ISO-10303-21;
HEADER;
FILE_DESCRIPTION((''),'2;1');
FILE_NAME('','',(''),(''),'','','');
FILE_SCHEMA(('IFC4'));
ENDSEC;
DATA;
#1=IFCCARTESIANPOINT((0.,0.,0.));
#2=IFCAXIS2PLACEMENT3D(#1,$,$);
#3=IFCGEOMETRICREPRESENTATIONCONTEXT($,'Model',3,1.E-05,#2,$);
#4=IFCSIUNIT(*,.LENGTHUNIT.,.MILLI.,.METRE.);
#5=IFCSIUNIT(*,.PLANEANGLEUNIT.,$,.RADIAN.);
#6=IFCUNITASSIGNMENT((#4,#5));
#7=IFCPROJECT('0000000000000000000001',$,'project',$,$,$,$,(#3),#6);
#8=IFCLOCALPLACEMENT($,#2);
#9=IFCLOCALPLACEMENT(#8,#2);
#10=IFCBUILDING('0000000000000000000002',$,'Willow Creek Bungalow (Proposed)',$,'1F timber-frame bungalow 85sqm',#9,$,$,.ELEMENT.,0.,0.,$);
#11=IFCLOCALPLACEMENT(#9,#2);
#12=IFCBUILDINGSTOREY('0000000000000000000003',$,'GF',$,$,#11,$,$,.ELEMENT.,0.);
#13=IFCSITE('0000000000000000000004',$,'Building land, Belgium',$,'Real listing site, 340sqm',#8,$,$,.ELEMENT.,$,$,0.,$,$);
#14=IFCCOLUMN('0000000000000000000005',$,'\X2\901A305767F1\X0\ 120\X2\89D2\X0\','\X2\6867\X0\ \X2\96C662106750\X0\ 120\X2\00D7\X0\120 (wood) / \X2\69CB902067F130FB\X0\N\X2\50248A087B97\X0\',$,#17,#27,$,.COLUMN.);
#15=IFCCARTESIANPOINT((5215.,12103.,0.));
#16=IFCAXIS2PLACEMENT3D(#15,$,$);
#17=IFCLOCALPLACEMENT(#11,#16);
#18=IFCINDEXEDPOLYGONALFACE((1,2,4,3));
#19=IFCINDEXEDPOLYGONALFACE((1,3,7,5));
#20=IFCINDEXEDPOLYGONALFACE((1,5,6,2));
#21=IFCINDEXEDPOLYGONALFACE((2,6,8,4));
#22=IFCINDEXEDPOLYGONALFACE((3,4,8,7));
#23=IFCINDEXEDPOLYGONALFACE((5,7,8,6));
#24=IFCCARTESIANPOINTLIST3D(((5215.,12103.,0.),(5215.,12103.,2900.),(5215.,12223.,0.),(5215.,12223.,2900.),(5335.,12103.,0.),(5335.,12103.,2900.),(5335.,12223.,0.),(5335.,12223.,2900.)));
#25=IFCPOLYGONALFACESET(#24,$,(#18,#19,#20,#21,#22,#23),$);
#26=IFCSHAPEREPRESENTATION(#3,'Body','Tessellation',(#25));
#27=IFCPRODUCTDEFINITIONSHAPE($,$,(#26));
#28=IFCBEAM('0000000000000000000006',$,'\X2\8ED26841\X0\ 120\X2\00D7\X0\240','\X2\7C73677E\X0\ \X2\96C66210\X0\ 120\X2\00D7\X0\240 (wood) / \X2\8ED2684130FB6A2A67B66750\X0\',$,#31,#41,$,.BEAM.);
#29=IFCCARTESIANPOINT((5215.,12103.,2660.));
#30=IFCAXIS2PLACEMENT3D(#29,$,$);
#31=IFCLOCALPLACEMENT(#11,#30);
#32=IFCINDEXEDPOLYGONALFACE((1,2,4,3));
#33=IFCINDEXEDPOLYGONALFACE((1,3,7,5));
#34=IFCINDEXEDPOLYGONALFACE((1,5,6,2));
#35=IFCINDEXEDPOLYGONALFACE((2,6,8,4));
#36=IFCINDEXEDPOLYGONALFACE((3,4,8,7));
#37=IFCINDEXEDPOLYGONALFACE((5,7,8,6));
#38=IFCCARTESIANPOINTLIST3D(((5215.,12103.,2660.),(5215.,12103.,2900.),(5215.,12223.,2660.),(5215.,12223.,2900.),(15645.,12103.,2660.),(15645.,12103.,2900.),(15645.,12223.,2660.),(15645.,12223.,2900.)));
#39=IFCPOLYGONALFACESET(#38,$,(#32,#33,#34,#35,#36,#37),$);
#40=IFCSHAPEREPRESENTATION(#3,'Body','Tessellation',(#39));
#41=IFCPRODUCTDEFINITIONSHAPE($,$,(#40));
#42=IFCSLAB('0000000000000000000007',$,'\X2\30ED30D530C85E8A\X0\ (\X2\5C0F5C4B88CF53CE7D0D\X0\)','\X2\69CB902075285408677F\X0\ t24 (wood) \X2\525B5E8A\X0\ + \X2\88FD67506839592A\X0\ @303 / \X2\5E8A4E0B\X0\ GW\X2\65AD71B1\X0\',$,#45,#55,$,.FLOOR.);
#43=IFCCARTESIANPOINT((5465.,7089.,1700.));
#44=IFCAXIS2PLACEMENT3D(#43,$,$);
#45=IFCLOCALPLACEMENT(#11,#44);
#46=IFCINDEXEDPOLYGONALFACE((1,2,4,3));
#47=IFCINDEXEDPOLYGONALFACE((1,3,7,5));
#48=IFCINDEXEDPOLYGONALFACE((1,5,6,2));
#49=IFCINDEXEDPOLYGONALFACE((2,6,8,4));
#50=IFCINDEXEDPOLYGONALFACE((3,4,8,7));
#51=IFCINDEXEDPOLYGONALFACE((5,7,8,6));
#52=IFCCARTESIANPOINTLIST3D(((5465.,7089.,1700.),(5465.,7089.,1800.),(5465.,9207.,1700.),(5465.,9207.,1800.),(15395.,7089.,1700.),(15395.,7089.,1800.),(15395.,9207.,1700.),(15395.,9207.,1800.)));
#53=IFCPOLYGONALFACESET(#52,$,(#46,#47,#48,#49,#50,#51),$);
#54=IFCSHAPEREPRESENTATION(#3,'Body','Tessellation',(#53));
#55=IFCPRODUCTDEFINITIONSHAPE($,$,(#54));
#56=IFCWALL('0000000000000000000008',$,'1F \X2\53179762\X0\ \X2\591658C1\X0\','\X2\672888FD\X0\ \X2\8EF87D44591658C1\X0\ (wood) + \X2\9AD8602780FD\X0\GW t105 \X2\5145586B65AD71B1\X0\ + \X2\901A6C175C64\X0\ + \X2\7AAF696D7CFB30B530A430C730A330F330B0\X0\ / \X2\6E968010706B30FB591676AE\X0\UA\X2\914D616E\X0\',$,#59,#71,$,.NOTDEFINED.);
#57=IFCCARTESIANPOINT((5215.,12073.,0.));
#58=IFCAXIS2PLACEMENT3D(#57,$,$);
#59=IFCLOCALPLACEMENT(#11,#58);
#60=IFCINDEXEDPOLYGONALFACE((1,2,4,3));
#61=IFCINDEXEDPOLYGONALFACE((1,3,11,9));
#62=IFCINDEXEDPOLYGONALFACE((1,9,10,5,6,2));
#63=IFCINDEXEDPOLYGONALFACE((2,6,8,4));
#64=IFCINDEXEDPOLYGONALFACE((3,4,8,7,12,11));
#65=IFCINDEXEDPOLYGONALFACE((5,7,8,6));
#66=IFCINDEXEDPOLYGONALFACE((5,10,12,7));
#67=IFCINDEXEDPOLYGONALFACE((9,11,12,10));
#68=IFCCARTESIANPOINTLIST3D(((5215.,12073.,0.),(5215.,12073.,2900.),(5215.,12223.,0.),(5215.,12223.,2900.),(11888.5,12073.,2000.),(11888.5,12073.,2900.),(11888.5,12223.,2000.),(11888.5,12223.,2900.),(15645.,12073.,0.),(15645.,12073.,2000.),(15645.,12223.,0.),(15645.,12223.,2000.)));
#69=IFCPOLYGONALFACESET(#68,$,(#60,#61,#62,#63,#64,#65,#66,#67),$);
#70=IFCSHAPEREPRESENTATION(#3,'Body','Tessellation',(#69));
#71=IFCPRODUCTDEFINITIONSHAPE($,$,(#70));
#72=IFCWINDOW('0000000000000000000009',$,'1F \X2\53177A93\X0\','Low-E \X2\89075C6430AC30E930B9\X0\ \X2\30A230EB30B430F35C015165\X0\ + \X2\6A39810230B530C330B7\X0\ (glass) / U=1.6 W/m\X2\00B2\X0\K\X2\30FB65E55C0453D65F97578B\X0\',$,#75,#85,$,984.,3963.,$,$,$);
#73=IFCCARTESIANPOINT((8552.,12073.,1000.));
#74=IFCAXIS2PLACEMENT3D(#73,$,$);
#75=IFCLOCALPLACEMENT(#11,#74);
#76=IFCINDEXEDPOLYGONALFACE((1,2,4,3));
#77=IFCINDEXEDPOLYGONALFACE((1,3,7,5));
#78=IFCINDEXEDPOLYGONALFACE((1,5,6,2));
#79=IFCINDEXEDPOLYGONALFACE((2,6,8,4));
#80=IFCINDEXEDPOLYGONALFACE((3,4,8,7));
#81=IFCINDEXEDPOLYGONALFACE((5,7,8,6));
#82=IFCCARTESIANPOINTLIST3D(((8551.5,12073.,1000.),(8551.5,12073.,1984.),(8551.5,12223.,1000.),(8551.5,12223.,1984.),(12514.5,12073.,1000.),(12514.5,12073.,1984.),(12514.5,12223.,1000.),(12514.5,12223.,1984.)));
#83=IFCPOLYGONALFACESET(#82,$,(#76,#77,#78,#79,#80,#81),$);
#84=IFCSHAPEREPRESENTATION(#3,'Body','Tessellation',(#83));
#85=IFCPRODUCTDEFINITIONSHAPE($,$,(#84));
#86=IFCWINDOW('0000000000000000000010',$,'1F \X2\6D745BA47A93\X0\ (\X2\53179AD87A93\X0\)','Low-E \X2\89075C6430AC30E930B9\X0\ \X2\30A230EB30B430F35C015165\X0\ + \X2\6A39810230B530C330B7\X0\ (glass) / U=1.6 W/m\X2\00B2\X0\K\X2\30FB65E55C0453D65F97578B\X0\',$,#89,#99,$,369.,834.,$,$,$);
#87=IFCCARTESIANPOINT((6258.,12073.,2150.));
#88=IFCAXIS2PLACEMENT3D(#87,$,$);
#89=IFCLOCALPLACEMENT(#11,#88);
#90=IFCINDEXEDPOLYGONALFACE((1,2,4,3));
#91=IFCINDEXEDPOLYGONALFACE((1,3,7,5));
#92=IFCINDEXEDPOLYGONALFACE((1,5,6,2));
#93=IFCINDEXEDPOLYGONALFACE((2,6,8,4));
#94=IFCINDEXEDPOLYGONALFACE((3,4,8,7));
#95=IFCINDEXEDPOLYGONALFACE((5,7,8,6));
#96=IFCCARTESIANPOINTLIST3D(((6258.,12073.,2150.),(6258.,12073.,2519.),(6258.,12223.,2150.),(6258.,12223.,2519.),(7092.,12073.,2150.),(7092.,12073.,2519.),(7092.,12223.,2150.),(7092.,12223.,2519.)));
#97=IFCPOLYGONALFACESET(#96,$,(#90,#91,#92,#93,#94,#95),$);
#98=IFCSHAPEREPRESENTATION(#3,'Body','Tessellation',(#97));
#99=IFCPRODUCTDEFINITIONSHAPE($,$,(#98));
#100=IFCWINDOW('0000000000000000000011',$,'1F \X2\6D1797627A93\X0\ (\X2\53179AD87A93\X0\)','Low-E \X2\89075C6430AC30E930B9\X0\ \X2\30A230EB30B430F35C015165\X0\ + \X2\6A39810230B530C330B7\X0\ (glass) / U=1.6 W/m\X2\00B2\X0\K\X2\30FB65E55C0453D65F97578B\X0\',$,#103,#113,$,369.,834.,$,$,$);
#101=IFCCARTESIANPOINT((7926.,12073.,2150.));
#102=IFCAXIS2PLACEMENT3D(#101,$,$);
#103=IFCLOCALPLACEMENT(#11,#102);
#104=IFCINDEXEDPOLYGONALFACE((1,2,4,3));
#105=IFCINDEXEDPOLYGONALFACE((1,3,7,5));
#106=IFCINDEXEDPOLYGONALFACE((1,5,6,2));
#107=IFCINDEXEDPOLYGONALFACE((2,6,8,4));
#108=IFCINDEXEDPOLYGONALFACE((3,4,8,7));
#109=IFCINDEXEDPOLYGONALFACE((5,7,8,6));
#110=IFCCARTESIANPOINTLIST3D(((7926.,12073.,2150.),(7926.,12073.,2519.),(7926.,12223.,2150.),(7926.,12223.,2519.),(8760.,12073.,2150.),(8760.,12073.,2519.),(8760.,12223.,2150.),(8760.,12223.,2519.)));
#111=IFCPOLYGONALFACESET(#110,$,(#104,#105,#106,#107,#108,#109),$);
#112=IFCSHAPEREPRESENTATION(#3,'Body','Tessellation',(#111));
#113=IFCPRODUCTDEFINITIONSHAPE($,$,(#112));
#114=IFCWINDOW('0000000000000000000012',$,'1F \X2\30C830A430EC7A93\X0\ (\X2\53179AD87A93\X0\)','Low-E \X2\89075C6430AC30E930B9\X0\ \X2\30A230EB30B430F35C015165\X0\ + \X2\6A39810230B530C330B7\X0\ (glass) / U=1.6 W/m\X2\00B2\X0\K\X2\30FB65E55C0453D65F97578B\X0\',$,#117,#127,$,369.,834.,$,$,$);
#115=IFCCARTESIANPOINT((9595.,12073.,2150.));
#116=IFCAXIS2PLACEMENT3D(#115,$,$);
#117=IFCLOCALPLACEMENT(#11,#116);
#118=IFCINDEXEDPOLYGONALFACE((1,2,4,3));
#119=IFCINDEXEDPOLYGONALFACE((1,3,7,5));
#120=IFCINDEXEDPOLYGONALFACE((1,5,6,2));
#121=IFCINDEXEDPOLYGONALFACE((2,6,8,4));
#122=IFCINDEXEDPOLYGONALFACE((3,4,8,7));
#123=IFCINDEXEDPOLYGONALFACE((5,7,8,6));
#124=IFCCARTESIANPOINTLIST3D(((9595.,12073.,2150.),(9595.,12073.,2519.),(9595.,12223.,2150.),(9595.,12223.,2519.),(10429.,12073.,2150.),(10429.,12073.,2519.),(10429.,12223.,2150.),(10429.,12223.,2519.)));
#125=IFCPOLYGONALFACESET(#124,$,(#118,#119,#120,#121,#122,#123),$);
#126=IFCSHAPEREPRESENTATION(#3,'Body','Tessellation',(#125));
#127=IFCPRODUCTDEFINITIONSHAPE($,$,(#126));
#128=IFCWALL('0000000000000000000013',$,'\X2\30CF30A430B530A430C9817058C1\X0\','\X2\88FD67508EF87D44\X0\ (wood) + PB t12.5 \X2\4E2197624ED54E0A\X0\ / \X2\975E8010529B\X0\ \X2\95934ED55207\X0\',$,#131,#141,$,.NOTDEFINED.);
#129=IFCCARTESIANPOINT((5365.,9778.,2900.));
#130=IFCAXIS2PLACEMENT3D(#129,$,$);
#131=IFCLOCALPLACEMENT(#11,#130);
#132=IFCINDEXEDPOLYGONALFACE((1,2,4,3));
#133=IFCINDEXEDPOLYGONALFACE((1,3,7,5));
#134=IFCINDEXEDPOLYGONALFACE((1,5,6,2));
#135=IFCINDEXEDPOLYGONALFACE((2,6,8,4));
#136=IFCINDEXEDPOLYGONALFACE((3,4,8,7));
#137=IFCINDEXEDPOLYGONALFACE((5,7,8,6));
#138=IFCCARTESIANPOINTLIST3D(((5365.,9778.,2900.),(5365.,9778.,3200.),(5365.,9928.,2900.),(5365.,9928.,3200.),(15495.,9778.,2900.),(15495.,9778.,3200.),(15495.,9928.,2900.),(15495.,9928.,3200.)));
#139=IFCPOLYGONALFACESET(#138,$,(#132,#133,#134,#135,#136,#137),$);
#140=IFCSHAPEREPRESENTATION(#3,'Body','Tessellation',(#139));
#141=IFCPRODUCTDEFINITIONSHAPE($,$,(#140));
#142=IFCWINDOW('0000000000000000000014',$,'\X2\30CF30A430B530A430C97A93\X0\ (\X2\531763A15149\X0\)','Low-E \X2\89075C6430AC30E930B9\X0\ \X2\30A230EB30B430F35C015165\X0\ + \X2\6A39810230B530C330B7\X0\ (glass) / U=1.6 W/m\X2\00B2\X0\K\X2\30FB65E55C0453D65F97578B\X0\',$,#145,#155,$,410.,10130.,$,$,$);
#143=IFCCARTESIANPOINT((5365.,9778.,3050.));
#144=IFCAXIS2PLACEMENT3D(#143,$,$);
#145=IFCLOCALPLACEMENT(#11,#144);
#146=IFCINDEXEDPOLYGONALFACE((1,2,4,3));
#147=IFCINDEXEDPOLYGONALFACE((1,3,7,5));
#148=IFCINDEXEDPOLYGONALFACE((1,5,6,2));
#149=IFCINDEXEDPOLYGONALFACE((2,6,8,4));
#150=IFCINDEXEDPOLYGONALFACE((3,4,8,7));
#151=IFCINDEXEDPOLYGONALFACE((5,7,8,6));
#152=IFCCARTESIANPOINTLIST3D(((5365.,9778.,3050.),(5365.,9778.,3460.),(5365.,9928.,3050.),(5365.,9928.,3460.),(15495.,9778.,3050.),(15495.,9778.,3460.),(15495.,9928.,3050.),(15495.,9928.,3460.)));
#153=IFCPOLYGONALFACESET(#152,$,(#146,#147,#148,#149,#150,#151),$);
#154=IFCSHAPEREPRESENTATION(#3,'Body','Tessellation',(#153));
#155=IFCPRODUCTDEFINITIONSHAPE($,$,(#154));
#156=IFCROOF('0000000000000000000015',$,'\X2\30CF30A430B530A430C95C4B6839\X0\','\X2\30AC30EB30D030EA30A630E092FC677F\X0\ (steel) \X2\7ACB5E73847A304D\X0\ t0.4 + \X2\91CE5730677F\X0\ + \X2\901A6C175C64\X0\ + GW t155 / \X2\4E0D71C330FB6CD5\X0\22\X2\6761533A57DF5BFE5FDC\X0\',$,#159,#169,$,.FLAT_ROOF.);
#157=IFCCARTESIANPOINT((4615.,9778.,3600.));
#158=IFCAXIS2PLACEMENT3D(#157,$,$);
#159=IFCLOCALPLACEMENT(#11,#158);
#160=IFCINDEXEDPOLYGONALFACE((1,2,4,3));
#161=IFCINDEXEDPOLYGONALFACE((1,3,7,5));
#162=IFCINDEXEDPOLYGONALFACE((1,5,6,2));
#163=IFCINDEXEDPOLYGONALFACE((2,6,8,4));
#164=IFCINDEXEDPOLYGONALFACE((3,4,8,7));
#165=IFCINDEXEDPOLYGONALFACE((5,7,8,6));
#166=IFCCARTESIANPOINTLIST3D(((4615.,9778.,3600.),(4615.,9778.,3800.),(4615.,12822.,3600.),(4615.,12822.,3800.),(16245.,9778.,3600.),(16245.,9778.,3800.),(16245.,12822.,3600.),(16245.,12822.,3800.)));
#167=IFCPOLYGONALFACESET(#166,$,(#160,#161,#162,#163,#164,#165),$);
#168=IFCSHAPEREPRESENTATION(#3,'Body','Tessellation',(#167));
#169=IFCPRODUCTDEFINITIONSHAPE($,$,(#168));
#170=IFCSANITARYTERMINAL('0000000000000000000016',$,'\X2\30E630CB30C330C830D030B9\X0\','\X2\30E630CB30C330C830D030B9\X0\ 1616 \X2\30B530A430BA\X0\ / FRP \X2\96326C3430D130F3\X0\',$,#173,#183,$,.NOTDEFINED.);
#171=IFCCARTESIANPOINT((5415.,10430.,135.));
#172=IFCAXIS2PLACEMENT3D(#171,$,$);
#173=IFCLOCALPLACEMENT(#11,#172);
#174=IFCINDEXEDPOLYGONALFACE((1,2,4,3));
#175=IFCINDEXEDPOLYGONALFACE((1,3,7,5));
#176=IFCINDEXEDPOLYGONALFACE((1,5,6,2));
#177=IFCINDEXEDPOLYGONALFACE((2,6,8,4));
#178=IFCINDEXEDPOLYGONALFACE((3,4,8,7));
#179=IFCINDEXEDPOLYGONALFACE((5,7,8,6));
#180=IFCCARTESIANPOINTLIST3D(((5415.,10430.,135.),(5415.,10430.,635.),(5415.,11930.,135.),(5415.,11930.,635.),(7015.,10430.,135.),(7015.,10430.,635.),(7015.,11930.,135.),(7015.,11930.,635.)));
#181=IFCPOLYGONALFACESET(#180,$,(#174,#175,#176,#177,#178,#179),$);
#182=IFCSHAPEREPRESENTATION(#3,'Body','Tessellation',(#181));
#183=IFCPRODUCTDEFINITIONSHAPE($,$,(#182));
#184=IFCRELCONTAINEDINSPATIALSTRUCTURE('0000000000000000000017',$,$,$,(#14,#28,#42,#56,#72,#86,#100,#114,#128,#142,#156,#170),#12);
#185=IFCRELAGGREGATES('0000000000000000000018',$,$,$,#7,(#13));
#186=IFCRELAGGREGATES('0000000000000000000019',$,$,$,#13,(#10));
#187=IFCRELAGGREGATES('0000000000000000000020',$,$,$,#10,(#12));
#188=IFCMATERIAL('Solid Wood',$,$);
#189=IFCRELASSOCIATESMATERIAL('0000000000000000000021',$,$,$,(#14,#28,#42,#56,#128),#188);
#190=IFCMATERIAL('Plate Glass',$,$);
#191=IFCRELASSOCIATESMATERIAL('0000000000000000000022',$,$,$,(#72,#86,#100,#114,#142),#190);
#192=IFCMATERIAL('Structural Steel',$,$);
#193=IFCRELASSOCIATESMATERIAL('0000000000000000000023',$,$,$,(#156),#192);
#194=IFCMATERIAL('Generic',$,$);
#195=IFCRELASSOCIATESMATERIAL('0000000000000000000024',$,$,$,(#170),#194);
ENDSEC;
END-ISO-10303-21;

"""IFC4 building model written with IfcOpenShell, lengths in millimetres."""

from ifc_helpers import new_model, si_unit, frame, frame_2d, origin, place, context, project, spatial, rectangle, extrude, material, element, fill, save


model = new_model("IFC4")

# Units and contexts
model_context = context("Model", 3, precision=1e-05, world=origin())
ifc_project = project(units=[si_unit("LENGTHUNIT", "METRE", prefix="MILLI"), si_unit("PLANEANGLEUNIT", "RADIAN")], contexts=[model_context])

# Site, building, storey
site_placement = place(None, origin())
site = spatial("IfcSite", under=ifc_project, at=site_placement, Name="Building land, Belgium", ObjectType="Real listing site, 340sqm", CompositionType="ELEMENT", RefElevation=0.0)
building_placement = place(site_placement, origin())
building = spatial("IfcBuilding", under=site, at=building_placement, Name="Willow Creek Bungalow (Proposed)", ObjectType="1F timber-frame bungalow 85sqm", CompositionType="ELEMENT", ElevationOfRefHeight=0.0, ElevationOfTerrain=0.0)
storey_placement = place(building_placement, origin())
storey = spatial("IfcBuildingStorey", under=building, at=storey_placement, Name="GF", CompositionType="ELEMENT", Elevation=0.0)

# Column
ifc_material_1 = material(Name="Solid Wood")
column_1_placement = place(storey_placement, frame((5215.0, 12103.0, 0.0)))
element("IfcColumn", 1, at=column_1_placement, inside=storey, material=ifc_material_1, Name="通し柱 120角", Description="桧 集成材 120×120 (wood) / 構造柱・N値計算", PredefinedType="COLUMN", context=model_context, shape_type="SweptSolid", body=[
    extrude(rectangle(XDim=120.0, YDim=120.0, at=frame_2d((60.0, 60.0))), frame((5215.0, 12103.0, 0.0)), (0.0, 0.0, 1.0), 2900.0),
])

# Beam
beam_1_placement = place(storey_placement, frame((5215.0, 12103.0, 2660.0)))
element("IfcBeam", 2, at=beam_1_placement, inside=storey, material=ifc_material_1, Name="軒桁 120×240", Description="米松 集成 120×240 (wood) / 軒桁・横架材", PredefinedType="BEAM", context=model_context, shape_type="SweptSolid", body=[
    extrude(rectangle(XDim=10430.0, YDim=120.0, at=frame_2d((5215.0, 60.0))), frame((5215.0, 12103.0, 2660.0)), (0.0, 0.0, 1.0), 240.0),
])

# Slab
slab_placement = place(storey_placement, frame((5465.0, 7089.0, 1700.0)))
element("IfcSlab", 3, at=slab_placement, inside=storey, material=ifc_material_1, Name="ロフト床 (小屋裏収納)", Description="構造用合板 t24 (wood) 剛床 + 製材根太 @303 / 床下 GW断熱", PredefinedType="FLOOR", context=model_context, shape_type="SweptSolid", body=[
    extrude(rectangle(XDim=9930.0, YDim=2118.0, at=frame_2d((4965.0, 1059.0))), frame((5465.0, 7089.0, 1700.0)), (0.0, 0.0, 1.0), 100.0),
])

# Wall, openings, windows
wall_1_placement = place(storey_placement, frame((5215.0, 12073.0, 0.0)))
wall_1 = element("IfcWall", 4, at=wall_1_placement, inside=storey, material=ifc_material_1, Name="1F 北面 外壁", Description="木製 軸組外壁 (wood) + 高性能GW t105 充填断熱 + 通気層 + 窯業系サイディング / 準耐火・外皮UA配慮", PredefinedType="NOTDEFINED", context=model_context, shape_type="SweptSolid", body=[
    extrude(rectangle(XDim=10430.0, YDim=150.0, at=frame_2d((5215.0, 75.0))), frame((5215.0, 12073.0, 0.0)), (0.0, 0.0, 1.0), 2900.0),
])
opening_1_placement = place(storey_placement, frame((8552.0, 12073.0, 1000.0)))
opening_1 = element("IfcOpeningElement", 5, at=opening_1_placement, cuts=wall_1, PredefinedType="NOTDEFINED", context=model_context, shape_type="SweptSolid", body=[
    extrude(rectangle(XDim=3963.0, YDim=150.0, at=frame_2d((1981.0, 75.0))), frame((8552.0, 12073.0, 1000.0)), (0.0, 0.0, 1.0), 984.0),
])
opening_2_placement = place(storey_placement, frame((6258.0, 12073.0, 2150.0)))
opening_2 = element("IfcOpeningElement", 6, at=opening_2_placement, cuts=wall_1, PredefinedType="NOTDEFINED", context=model_context, shape_type="SweptSolid", body=[
    extrude(rectangle(XDim=834.0, YDim=150.0, at=frame_2d((417.0, 75.0))), frame((6258.0, 12073.0, 2150.0)), (0.0, 0.0, 1.0), 369.0),
])
opening_3_placement = place(storey_placement, frame((7926.0, 12073.0, 2150.0)))
opening_3 = element("IfcOpeningElement", 7, at=opening_3_placement, cuts=wall_1, PredefinedType="NOTDEFINED", context=model_context, shape_type="SweptSolid", body=[
    extrude(rectangle(XDim=834.0, YDim=150.0, at=frame_2d((417.0, 75.0))), frame((7926.0, 12073.0, 2150.0)), (0.0, 0.0, 1.0), 369.0),
])
opening_4_placement = place(storey_placement, frame((9595.0, 12073.0, 2150.0)))
opening_4 = element("IfcOpeningElement", 8, at=opening_4_placement, cuts=wall_1, PredefinedType="NOTDEFINED", context=model_context, shape_type="SweptSolid", body=[
    extrude(rectangle(XDim=834.0, YDim=150.0, at=frame_2d((417.0, 75.0))), frame((9595.0, 12073.0, 2150.0)), (0.0, 0.0, 1.0), 369.0),
])
ifc_material_2 = material(Name="Plate Glass")
window_1_placement = place(storey_placement, frame((8552.0, 12073.0, 1000.0)))
window_1 = element("IfcWindow", 9, at=window_1_placement, inside=storey, material=ifc_material_2, Name="1F 北窓", Description="Low-E 複層ガラス アルゴン封入 + 樹脂サッシ (glass) / U=1.6 W/m²K・日射取得型", OverallHeight=984.0, OverallWidth=3963.0, context=model_context, shape_type="SweptSolid", body=[
    extrude(rectangle(XDim=3963.0, YDim=150.0, at=frame_2d((1981.0, 75.0))), frame((8552.0, 12073.0, 1000.0)), (0.0, 0.0, 1.0), 984.0),
])
fill(opening_1, window_1)
window_2_placement = place(storey_placement, frame((6258.0, 12073.0, 2150.0)))
window_2 = element("IfcWindow", 10, at=window_2_placement, inside=storey, material=ifc_material_2, Name="1F 浴室窓 (北高窓)", Description="Low-E 複層ガラス アルゴン封入 + 樹脂サッシ (glass) / U=1.6 W/m²K・日射取得型", OverallHeight=369.0, OverallWidth=834.0, context=model_context, shape_type="SweptSolid", body=[
    extrude(rectangle(XDim=834.0, YDim=150.0, at=frame_2d((417.0, 75.0))), frame((6258.0, 12073.0, 2150.0)), (0.0, 0.0, 1.0), 369.0),
])
fill(opening_2, window_2)
window_3_placement = place(storey_placement, frame((7926.0, 12073.0, 2150.0)))
window_3 = element("IfcWindow", 11, at=window_3_placement, inside=storey, material=ifc_material_2, Name="1F 洗面窓 (北高窓)", Description="Low-E 複層ガラス アルゴン封入 + 樹脂サッシ (glass) / U=1.6 W/m²K・日射取得型", OverallHeight=369.0, OverallWidth=834.0, context=model_context, shape_type="SweptSolid", body=[
    extrude(rectangle(XDim=834.0, YDim=150.0, at=frame_2d((417.0, 75.0))), frame((7926.0, 12073.0, 2150.0)), (0.0, 0.0, 1.0), 369.0),
])
fill(opening_3, window_3)
window_4_placement = place(storey_placement, frame((9595.0, 12073.0, 2150.0)))
window_4 = element("IfcWindow", 12, at=window_4_placement, inside=storey, material=ifc_material_2, Name="1F トイレ窓 (北高窓)", Description="Low-E 複層ガラス アルゴン封入 + 樹脂サッシ (glass) / U=1.6 W/m²K・日射取得型", OverallHeight=369.0, OverallWidth=834.0, context=model_context, shape_type="SweptSolid", body=[
    extrude(rectangle(XDim=834.0, YDim=150.0, at=frame_2d((417.0, 75.0))), frame((9595.0, 12073.0, 2150.0)), (0.0, 0.0, 1.0), 369.0),
])
fill(opening_4, window_4)

# Wall, opening, window
wall_2_placement = place(storey_placement, frame((5365.0, 9778.0, 2900.0)))
wall_2 = element("IfcWall", 13, at=wall_2_placement, inside=storey, material=ifc_material_1, Name="ハイサイド腰壁", Description="製材軸組 (wood) + PB t12.5 両面仕上 / 非耐力 間仕切", PredefinedType="NOTDEFINED", context=model_context, shape_type="SweptSolid", body=[
    extrude(rectangle(XDim=10130.0, YDim=150.0, at=frame_2d((5065.0, 75.0))), frame((5365.0, 9778.0, 2900.0)), (0.0, 0.0, 1.0), 700.0),
])
opening_5_placement = place(storey_placement, frame((5365.0, 9778.0, 3050.0)))
opening_5 = element("IfcOpeningElement", 14, at=opening_5_placement, cuts=wall_2, PredefinedType="NOTDEFINED", context=model_context, shape_type="SweptSolid", body=[
    extrude(rectangle(XDim=10130.0, YDim=150.0, at=frame_2d((5065.0, 75.0))), frame((5365.0, 9778.0, 3050.0)), (0.0, 0.0, 1.0), 410.0),
])
window_5_placement = place(storey_placement, frame((5365.0, 9778.0, 3050.0)))
window_5 = element("IfcWindow", 15, at=window_5_placement, inside=storey, material=ifc_material_2, Name="ハイサイド窓 (北採光)", Description="Low-E 複層ガラス アルゴン封入 + 樹脂サッシ (glass) / U=1.6 W/m²K・日射取得型", OverallHeight=410.0, OverallWidth=10130.0, context=model_context, shape_type="SweptSolid", body=[
    extrude(rectangle(XDim=10130.0, YDim=150.0, at=frame_2d((5065.0, 75.0))), frame((5365.0, 9778.0, 3050.0)), (0.0, 0.0, 1.0), 410.0),
])
fill(opening_5, window_5)

# Roof
ifc_material_3 = material(Name="Structural Steel")
roof_placement = place(storey_placement, frame((4615.0, 9778.0, 3600.0)))
element("IfcRoof", 16, at=roof_placement, inside=storey, material=ifc_material_3, Name="ハイサイド屋根", Description="ガルバリウム鋼板 (steel) 立平葺き t0.4 + 野地板 + 通気層 + GW t155 / 不燃・法22条区域対応", PredefinedType="FLAT_ROOF", context=model_context, shape_type="SweptSolid", body=[
    extrude(rectangle(XDim=11630.0, YDim=3044.0, at=frame_2d((5815.0, 1522.0))), frame((4615.0, 9778.0, 3600.0)), (0.0, 0.0, 1.0), 200.0),
])

# Sanitary terminal
ifc_material_4 = material(Name="Generic")
sanitary_terminal_placement = place(storey_placement, frame((5415.0, 10430.0, 135.0)))
element("IfcSanitaryTerminal", 17, at=sanitary_terminal_placement, inside=storey, material=ifc_material_4, Name="ユニットバス", Description="ユニットバス 1616 サイズ / FRP 防水パン", PredefinedType="NOTDEFINED", context=model_context, shape_type="SweptSolid", body=[
    extrude(rectangle(XDim=1600.0, YDim=1500.0, at=frame_2d((800.0, 750.0))), frame((5415.0, 10430.0, 135.0)), (0.0, 0.0, 1.0), 500.0),
])

save(model, "model.ifc")
